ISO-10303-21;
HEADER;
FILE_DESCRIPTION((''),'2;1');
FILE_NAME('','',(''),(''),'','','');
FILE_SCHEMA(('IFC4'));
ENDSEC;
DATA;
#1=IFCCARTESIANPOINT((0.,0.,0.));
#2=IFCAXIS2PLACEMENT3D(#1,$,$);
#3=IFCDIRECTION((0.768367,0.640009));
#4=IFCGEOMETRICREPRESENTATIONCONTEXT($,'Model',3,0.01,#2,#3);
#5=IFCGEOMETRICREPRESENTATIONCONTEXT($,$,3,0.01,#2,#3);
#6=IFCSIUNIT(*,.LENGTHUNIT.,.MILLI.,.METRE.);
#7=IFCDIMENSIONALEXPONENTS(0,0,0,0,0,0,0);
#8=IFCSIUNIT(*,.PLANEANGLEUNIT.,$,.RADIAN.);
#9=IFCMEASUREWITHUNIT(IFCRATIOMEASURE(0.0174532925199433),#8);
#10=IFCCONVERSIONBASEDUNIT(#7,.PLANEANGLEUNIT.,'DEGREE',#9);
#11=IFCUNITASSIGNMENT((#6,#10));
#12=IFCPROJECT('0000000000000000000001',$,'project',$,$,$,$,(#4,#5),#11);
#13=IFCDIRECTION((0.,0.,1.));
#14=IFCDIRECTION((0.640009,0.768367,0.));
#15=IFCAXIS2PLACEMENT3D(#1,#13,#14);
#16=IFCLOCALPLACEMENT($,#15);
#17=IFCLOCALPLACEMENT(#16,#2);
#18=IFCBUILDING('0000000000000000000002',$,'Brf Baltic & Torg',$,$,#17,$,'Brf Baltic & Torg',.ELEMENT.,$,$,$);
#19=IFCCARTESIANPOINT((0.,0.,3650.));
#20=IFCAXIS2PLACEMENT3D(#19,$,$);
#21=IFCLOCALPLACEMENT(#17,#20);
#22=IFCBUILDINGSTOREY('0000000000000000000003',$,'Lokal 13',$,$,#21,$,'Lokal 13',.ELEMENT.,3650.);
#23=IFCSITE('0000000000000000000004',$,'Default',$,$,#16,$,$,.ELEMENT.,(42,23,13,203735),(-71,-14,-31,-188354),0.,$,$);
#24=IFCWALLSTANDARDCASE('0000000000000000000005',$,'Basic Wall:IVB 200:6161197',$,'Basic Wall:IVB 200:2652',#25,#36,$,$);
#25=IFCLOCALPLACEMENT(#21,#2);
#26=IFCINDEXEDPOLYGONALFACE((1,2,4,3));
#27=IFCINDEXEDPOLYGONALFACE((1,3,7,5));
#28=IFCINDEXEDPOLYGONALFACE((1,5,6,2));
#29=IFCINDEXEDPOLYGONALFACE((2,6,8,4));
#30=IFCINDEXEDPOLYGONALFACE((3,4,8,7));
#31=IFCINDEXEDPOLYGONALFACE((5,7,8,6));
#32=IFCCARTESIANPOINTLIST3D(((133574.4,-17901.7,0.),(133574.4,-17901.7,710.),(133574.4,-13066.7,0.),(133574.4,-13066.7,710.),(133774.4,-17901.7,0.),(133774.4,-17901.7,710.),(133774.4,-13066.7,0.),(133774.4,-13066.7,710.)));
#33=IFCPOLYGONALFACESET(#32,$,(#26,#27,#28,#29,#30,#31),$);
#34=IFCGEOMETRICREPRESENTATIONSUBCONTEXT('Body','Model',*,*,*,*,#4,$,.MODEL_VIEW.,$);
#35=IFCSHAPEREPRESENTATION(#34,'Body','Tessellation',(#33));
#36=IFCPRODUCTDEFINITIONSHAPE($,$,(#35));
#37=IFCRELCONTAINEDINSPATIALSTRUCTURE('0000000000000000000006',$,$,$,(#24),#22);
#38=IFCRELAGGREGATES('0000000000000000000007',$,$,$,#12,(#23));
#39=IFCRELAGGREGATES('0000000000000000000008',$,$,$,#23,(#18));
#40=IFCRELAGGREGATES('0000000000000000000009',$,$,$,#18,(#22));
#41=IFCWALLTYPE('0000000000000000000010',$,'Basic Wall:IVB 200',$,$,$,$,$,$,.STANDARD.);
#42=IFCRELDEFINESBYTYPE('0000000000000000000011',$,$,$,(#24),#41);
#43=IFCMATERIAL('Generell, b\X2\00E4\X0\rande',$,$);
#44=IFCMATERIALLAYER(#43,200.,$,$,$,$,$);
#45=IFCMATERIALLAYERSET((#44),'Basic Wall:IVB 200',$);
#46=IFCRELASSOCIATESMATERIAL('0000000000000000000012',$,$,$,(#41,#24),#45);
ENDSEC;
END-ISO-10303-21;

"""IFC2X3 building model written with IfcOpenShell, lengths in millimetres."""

from ifc_helpers import new_model, entity, si_unit, converted_unit, direction, frame, frame_2d, origin, place, context, subcontext, project, spatial, rectangle, extrude, clip, halfspace, material, layer, layer_set, layer_usage, type_object, element, save


model = new_model("IFC2X3")

# Units and contexts
model_context = context("Model", 3, precision=0.01, world=origin(), true_north=direction((0.768367, 0.640009)))
context_of_model = context(None, 3, precision=0.01, world=origin(), true_north=direction((0.768367, 0.640009)))
body_context = subcontext(model_context, "Body", "Model", "MODEL_VIEW")
ifc_project = project(units=[si_unit("LENGTHUNIT", "METRE", prefix="MILLI"), converted_unit("PLANEANGLEUNIT", "DEGREE", entity("IfcRatioMeasure", 0.0174532925199433), si_unit("PLANEANGLEUNIT", "RADIAN"), dimensions=[0, 0, 0, 0, 0, 0, 0])], contexts=[model_context, context_of_model])

# Site, building, storey
site_placement = place(None, frame((0.0, 0.0, 0.0), z_axis=(0.0, 0.0, 1.0), x_axis=(0.640009, 0.768367, 0.0)))
site = spatial("IfcSite", under=ifc_project, at=site_placement, Name="Default", CompositionType="ELEMENT", RefLatitude=(42, 23, 13, 203735), RefLongitude=(-71, -14, -31, -188354), RefElevation=0.0)
building_placement = place(site_placement, origin())
building = spatial("IfcBuilding", under=site, at=building_placement, Name="Brf Baltic & Torg", LongName="Brf Baltic & Torg", CompositionType="ELEMENT")
storey_placement = place(building_placement, frame((0.0, 0.0, 3650.0)))
storey = spatial("IfcBuildingStorey", under=building, at=storey_placement, Name="Lokal 13", LongName="Lokal 13", CompositionType="ELEMENT", Elevation=3650.0)

# Shared definitions
ifc_material_1 = material(Name="Generell, bärande")

# Shared definitions
ifc_layer_1 = layer(ifc_material_1, 200.0)
ifc_layer_set_1 = layer_set([ifc_layer_1], Name="Basic Wall:IVB 200")
wall_type = type_object("IfcWallType", Name="Basic Wall:IVB 200", PredefinedType="STANDARD", material=ifc_layer_set_1)

# Wall
ifc_layer_usage_1 = layer_usage(ifc_layer_set_1, "AXIS2", "NEGATIVE", 100.0)
wall_1_placement = place(storey_placement, frame((133674.4, -17901.7, 0.0), z_axis=(0.0, 0.0, 1.0), x_axis=(0.0, 1.0, 0.0)))
element("IfcWallStandardCase", 1, at=wall_1_placement, inside=storey, type_object=wall_type, material=ifc_layer_usage_1, Name="Basic Wall:IVB 200:6161197", ObjectType="Basic Wall:IVB 200:2652", context=body_context, shape_type="Clipping", body=[
    clip(extrude(rectangle(XDim=4835.0, YDim=200.0, at=frame_2d((2417.5, 0.0), x_axis=(-1.0, 0.0))), origin(), (0.0, 0.0, 1.0), 710.0), halfspace(frame((0.0, 0.0, -2000.0)), True)),
])

save(model, "model.ifc")
